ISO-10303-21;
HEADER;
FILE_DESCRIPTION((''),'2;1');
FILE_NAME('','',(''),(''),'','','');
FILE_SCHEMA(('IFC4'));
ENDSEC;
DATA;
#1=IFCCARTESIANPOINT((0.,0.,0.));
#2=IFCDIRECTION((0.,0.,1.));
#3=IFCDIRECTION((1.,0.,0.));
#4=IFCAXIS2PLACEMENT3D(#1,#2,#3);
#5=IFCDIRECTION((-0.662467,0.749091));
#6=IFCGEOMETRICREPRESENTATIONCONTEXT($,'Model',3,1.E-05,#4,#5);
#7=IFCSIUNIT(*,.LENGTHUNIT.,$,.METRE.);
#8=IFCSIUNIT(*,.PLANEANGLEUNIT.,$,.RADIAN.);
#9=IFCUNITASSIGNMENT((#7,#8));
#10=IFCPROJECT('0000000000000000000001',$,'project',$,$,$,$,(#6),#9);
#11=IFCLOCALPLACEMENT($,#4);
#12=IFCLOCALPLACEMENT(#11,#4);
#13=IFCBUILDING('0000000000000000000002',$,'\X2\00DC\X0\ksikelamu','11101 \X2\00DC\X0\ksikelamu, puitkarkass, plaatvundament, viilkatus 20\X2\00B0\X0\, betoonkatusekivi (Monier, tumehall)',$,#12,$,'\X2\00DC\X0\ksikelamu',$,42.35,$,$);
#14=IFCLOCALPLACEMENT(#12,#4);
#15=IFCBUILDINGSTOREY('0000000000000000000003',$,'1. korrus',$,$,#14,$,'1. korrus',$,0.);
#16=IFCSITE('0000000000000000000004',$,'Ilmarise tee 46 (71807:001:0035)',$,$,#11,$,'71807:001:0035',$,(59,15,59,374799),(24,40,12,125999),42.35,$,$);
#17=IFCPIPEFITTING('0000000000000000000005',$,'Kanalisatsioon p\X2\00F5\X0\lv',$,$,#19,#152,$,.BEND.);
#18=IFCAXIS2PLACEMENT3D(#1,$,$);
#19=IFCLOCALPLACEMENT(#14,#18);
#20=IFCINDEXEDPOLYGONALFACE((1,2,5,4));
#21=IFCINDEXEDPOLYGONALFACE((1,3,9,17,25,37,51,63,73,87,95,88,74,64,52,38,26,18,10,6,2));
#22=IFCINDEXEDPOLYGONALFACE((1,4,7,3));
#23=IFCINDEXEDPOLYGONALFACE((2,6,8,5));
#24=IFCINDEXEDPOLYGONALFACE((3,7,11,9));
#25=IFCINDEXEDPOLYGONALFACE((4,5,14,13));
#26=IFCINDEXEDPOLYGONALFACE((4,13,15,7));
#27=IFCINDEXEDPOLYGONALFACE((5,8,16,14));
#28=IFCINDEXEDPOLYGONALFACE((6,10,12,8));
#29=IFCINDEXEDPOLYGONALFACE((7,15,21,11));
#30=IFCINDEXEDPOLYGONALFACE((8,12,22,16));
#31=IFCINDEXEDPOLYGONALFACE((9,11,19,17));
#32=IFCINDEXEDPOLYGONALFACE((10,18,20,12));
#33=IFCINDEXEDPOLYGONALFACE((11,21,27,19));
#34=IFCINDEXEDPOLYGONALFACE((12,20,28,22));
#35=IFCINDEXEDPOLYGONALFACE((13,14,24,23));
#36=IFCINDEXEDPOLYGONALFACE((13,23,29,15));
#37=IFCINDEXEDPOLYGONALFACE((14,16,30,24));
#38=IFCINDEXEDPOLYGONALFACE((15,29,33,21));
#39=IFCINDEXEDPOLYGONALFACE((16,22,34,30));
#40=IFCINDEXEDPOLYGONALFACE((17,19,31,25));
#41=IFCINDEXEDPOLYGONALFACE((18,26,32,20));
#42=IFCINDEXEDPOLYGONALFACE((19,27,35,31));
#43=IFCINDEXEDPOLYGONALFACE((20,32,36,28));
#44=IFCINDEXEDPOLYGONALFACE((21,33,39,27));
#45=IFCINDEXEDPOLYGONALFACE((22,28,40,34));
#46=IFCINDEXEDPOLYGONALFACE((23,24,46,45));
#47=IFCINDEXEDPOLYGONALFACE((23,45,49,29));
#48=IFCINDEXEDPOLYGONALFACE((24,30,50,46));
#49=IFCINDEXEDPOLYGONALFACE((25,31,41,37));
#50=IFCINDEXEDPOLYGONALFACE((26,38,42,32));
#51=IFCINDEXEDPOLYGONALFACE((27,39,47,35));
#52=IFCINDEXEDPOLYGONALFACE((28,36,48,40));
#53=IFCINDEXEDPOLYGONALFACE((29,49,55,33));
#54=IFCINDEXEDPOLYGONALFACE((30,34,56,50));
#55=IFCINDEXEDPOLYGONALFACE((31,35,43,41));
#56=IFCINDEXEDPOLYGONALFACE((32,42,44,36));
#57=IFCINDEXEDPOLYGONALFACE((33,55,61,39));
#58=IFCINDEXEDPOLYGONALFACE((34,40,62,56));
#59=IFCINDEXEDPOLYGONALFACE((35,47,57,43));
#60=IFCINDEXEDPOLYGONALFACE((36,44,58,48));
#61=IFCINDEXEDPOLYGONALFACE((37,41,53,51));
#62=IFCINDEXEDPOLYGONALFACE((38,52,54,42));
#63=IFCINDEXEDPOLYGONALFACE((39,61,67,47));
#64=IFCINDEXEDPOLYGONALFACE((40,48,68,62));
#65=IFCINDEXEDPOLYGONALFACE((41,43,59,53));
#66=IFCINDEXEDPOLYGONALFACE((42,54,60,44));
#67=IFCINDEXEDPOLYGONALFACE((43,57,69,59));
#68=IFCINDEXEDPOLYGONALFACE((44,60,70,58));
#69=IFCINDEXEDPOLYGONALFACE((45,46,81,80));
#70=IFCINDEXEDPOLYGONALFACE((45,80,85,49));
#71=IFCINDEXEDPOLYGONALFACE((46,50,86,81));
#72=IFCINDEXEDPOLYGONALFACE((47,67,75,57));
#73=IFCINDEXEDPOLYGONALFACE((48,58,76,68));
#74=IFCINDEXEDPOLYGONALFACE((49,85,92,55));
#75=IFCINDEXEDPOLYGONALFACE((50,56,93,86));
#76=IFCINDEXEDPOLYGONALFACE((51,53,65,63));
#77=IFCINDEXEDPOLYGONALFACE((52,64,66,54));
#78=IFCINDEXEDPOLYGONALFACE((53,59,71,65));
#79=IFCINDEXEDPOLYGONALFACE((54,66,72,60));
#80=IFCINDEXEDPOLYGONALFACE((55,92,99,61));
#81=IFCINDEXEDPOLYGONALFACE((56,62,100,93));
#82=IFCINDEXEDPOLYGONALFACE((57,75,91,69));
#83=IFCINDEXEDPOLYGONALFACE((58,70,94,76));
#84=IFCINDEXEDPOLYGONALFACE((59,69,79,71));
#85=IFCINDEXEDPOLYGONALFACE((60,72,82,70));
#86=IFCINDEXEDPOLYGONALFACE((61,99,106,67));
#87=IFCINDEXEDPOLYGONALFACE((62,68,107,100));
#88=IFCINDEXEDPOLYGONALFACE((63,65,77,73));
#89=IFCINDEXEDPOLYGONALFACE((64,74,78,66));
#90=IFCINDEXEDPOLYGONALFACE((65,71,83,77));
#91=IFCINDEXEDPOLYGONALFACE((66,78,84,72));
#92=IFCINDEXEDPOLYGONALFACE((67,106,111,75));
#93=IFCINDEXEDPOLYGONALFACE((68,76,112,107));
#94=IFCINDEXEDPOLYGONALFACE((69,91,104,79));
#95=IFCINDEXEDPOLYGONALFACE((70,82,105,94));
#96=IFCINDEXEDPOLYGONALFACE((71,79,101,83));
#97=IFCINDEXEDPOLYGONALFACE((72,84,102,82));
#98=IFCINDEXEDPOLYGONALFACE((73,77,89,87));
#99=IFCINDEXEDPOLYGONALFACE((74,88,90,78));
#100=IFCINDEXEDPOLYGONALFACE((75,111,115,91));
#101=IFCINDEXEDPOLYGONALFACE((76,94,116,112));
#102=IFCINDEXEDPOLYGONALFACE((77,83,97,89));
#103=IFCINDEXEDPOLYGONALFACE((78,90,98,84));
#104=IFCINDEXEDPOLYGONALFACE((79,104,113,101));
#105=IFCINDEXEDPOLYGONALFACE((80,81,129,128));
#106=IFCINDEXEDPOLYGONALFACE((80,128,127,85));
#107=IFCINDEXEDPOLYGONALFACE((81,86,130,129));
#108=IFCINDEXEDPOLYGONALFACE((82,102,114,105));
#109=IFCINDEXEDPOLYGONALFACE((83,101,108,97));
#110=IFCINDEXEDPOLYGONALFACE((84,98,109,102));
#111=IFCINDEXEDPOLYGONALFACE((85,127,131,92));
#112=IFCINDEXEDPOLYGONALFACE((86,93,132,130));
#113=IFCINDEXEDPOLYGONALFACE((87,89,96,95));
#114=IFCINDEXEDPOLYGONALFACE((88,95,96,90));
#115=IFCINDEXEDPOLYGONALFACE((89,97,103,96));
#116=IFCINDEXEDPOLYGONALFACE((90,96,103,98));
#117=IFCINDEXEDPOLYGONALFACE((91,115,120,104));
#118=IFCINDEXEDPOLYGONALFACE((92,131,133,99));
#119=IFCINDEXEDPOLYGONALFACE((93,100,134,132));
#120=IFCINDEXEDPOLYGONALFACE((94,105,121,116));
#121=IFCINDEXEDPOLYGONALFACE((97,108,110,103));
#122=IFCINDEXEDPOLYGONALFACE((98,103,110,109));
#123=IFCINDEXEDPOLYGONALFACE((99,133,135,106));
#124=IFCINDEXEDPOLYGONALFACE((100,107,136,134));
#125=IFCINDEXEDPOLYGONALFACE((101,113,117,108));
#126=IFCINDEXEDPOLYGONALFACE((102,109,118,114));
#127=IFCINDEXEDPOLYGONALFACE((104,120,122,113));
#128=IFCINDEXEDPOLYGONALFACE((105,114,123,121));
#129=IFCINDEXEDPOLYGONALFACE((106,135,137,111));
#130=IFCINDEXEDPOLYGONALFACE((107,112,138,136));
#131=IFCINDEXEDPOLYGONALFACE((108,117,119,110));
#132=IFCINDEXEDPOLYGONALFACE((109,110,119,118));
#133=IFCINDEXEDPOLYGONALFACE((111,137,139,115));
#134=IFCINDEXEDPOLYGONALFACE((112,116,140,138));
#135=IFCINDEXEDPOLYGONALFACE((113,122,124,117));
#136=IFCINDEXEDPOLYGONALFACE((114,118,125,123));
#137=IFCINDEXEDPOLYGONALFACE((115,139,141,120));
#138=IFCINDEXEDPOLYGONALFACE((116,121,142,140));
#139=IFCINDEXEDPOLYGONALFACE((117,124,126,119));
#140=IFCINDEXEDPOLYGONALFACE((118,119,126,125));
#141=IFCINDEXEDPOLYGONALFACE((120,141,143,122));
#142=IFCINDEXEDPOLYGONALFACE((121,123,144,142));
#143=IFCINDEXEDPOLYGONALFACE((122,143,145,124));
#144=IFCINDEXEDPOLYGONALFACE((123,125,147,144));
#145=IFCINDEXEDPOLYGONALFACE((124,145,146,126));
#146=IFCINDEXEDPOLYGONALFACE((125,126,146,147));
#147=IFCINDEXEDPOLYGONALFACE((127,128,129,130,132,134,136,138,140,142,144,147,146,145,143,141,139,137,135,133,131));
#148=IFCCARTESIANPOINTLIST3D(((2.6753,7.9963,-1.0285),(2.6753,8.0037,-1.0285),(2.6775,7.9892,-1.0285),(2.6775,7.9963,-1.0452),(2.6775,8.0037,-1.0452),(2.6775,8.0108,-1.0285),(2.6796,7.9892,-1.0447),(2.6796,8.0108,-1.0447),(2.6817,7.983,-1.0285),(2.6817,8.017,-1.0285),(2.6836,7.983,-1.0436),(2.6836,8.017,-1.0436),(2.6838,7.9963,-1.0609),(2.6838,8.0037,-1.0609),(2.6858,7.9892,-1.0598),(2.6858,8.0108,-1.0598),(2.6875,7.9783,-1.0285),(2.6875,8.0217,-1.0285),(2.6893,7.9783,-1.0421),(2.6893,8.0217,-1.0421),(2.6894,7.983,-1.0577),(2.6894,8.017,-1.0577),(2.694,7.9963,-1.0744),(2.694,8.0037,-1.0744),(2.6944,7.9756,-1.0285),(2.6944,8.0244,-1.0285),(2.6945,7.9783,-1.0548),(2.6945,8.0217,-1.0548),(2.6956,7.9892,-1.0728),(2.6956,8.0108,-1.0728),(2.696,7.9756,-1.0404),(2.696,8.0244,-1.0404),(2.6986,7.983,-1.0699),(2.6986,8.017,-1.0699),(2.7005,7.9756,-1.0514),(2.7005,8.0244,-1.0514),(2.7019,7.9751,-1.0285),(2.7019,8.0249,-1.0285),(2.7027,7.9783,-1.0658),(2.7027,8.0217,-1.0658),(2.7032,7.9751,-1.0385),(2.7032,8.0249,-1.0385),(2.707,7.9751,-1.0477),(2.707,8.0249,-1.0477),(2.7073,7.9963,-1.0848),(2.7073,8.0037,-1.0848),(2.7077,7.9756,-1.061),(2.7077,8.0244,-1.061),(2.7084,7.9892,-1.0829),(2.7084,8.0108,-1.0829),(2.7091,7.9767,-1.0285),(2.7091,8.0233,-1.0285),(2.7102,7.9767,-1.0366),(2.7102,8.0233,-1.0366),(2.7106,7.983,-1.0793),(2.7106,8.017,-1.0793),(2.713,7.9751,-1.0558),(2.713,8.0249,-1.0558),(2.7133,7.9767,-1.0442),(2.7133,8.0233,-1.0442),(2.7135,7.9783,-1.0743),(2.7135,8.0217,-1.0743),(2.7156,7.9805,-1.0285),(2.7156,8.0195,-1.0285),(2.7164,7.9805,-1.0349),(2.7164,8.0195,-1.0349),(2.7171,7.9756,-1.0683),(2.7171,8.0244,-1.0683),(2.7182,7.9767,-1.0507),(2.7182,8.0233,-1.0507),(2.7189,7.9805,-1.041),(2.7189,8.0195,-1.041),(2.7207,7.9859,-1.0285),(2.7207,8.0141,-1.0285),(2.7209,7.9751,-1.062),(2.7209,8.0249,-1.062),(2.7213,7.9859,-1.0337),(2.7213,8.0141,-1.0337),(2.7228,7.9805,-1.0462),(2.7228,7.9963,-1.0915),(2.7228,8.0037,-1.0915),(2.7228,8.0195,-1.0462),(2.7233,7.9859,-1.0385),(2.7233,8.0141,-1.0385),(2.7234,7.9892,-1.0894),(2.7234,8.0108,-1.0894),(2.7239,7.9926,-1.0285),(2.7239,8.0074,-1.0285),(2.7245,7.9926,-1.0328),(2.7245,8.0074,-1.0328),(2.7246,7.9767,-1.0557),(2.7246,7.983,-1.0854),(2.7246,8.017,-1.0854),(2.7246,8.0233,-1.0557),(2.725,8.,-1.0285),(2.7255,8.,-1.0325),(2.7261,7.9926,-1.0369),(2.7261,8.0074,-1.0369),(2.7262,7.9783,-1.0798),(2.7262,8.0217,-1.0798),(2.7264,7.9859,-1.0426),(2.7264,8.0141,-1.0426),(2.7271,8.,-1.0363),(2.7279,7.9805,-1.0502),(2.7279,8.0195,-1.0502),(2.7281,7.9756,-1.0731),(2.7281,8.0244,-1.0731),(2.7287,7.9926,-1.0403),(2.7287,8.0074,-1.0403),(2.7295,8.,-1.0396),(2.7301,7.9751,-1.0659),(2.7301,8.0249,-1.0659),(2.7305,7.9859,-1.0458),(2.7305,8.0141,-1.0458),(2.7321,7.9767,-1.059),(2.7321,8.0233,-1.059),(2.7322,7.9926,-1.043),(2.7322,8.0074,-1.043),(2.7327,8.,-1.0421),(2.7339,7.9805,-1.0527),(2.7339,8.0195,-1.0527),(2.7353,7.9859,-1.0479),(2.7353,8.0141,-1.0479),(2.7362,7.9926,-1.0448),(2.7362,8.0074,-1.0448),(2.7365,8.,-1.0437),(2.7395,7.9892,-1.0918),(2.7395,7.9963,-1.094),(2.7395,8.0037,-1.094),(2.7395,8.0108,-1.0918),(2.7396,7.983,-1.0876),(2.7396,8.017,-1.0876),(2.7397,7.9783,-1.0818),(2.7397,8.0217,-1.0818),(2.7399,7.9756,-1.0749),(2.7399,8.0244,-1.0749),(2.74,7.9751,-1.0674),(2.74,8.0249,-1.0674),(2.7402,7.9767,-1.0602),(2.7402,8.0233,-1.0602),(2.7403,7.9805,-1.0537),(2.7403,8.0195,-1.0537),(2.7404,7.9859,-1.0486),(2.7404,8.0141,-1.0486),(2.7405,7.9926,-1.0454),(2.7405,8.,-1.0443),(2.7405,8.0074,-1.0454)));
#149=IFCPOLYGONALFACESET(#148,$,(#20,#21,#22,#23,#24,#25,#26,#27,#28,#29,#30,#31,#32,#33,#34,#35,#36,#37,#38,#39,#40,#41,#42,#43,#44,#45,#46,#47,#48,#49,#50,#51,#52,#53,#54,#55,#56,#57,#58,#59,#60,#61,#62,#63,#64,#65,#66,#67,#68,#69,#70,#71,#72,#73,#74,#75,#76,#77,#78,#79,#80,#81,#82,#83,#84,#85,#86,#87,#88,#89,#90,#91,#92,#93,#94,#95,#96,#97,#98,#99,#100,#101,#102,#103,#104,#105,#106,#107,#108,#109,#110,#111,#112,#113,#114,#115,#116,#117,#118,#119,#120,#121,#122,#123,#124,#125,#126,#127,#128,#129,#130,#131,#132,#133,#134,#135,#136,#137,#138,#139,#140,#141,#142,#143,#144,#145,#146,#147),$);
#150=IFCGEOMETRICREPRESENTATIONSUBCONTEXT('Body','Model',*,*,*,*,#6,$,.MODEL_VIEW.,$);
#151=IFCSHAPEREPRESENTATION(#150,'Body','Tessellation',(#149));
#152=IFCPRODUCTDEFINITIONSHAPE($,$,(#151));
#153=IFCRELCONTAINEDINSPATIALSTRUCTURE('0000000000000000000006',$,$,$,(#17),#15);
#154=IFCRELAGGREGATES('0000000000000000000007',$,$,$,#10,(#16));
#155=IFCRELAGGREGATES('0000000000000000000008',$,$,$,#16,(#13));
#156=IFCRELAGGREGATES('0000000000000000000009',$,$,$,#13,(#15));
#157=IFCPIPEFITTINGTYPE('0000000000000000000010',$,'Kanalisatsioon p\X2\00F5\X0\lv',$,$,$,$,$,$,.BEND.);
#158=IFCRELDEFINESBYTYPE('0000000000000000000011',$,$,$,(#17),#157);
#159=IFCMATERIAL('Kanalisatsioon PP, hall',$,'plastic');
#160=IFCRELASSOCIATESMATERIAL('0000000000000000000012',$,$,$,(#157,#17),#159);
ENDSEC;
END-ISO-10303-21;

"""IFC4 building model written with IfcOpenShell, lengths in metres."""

from ifc_helpers import new_model, entity, si_unit, direction, frame, origin_with_axes, place, context, subcontext, project, spatial, material, type_object, element, save


model = new_model("IFC4")

# Units and contexts
model_context = context("Model", 3, precision=1e-05, world=origin_with_axes(), true_north=direction((-0.662467, 0.749091)))
body_context = subcontext(model_context, "Body", "Model", "MODEL_VIEW")
ifc_project = project(units=[si_unit("LENGTHUNIT", "METRE"), si_unit("PLANEANGLEUNIT", "RADIAN")], contexts=[model_context])

# Site, building, storey
site_placement = place(None, origin_with_axes())
site = spatial("IfcSite", under=ifc_project, at=site_placement, Name="Ilmarise tee 46 (71807:001:0035)", LongName="71807:001:0035", RefLatitude=(59, 15, 59, 374799), RefLongitude=(24, 40, 12, 125999), RefElevation=42.35)
building_placement = place(site_placement, origin_with_axes())
building = spatial("IfcBuilding", under=site, at=building_placement, Name="Üksikelamu", Description="11101 Üksikelamu, puitkarkass, plaatvundament, viilkatus 20°, betoonkatusekivi (Monier, tumehall)", LongName="Üksikelamu", ElevationOfRefHeight=42.35)
storey_placement = place(building_placement, origin_with_axes())
storey = spatial("IfcBuildingStorey", under=building, at=storey_placement, Name="1. korrus", LongName="1. korrus", Elevation=0.0)

# Pipe fitting
ifc_material_1 = material(Name="Kanalisatsioon PP, hall", Category="plastic")
pipe_fitting_type_1 = type_object("IfcPipeFittingType", Name="Kanalisatsioon põlv", PredefinedType="BEND", material=ifc_material_1)
pipe_fitting_1_placement = place(storey_placement, frame((2.7, 8.0, -1.0685), z_axis=(0.0, 0.0, 1.0), x_axis=(1.0, 0.0, 0.0)))
element("IfcPipeFitting", 1, at=pipe_fitting_1_placement, inside=storey, type_object=pipe_fitting_type_1, material=ifc_material_1, Name="Kanalisatsioon põlv", PredefinedType="BEND", context=body_context, shape_type="SweptSolid", body=[
    entity("IfcRevolvedAreaSolid", entity("IfcCircleProfileDef", "AREA", None, None, 0.025), entity("IfcAxis2Placement3D", entity("IfcCartesianPoint", [0.0, 0.0, 0.04]), entity("IfcDirection", [0.0, 0.0, -1.0]), entity("IfcDirection", [1.0, 0.0, 0.0])), entity("IfcAxis1Placement", entity("IfcCartesianPoint", [0.0408, 0.0, 0.0]), entity("IfcDirection", [0.0, 1.0, 0.0])), 1.550799),
])

save(model, "model.ifc")
